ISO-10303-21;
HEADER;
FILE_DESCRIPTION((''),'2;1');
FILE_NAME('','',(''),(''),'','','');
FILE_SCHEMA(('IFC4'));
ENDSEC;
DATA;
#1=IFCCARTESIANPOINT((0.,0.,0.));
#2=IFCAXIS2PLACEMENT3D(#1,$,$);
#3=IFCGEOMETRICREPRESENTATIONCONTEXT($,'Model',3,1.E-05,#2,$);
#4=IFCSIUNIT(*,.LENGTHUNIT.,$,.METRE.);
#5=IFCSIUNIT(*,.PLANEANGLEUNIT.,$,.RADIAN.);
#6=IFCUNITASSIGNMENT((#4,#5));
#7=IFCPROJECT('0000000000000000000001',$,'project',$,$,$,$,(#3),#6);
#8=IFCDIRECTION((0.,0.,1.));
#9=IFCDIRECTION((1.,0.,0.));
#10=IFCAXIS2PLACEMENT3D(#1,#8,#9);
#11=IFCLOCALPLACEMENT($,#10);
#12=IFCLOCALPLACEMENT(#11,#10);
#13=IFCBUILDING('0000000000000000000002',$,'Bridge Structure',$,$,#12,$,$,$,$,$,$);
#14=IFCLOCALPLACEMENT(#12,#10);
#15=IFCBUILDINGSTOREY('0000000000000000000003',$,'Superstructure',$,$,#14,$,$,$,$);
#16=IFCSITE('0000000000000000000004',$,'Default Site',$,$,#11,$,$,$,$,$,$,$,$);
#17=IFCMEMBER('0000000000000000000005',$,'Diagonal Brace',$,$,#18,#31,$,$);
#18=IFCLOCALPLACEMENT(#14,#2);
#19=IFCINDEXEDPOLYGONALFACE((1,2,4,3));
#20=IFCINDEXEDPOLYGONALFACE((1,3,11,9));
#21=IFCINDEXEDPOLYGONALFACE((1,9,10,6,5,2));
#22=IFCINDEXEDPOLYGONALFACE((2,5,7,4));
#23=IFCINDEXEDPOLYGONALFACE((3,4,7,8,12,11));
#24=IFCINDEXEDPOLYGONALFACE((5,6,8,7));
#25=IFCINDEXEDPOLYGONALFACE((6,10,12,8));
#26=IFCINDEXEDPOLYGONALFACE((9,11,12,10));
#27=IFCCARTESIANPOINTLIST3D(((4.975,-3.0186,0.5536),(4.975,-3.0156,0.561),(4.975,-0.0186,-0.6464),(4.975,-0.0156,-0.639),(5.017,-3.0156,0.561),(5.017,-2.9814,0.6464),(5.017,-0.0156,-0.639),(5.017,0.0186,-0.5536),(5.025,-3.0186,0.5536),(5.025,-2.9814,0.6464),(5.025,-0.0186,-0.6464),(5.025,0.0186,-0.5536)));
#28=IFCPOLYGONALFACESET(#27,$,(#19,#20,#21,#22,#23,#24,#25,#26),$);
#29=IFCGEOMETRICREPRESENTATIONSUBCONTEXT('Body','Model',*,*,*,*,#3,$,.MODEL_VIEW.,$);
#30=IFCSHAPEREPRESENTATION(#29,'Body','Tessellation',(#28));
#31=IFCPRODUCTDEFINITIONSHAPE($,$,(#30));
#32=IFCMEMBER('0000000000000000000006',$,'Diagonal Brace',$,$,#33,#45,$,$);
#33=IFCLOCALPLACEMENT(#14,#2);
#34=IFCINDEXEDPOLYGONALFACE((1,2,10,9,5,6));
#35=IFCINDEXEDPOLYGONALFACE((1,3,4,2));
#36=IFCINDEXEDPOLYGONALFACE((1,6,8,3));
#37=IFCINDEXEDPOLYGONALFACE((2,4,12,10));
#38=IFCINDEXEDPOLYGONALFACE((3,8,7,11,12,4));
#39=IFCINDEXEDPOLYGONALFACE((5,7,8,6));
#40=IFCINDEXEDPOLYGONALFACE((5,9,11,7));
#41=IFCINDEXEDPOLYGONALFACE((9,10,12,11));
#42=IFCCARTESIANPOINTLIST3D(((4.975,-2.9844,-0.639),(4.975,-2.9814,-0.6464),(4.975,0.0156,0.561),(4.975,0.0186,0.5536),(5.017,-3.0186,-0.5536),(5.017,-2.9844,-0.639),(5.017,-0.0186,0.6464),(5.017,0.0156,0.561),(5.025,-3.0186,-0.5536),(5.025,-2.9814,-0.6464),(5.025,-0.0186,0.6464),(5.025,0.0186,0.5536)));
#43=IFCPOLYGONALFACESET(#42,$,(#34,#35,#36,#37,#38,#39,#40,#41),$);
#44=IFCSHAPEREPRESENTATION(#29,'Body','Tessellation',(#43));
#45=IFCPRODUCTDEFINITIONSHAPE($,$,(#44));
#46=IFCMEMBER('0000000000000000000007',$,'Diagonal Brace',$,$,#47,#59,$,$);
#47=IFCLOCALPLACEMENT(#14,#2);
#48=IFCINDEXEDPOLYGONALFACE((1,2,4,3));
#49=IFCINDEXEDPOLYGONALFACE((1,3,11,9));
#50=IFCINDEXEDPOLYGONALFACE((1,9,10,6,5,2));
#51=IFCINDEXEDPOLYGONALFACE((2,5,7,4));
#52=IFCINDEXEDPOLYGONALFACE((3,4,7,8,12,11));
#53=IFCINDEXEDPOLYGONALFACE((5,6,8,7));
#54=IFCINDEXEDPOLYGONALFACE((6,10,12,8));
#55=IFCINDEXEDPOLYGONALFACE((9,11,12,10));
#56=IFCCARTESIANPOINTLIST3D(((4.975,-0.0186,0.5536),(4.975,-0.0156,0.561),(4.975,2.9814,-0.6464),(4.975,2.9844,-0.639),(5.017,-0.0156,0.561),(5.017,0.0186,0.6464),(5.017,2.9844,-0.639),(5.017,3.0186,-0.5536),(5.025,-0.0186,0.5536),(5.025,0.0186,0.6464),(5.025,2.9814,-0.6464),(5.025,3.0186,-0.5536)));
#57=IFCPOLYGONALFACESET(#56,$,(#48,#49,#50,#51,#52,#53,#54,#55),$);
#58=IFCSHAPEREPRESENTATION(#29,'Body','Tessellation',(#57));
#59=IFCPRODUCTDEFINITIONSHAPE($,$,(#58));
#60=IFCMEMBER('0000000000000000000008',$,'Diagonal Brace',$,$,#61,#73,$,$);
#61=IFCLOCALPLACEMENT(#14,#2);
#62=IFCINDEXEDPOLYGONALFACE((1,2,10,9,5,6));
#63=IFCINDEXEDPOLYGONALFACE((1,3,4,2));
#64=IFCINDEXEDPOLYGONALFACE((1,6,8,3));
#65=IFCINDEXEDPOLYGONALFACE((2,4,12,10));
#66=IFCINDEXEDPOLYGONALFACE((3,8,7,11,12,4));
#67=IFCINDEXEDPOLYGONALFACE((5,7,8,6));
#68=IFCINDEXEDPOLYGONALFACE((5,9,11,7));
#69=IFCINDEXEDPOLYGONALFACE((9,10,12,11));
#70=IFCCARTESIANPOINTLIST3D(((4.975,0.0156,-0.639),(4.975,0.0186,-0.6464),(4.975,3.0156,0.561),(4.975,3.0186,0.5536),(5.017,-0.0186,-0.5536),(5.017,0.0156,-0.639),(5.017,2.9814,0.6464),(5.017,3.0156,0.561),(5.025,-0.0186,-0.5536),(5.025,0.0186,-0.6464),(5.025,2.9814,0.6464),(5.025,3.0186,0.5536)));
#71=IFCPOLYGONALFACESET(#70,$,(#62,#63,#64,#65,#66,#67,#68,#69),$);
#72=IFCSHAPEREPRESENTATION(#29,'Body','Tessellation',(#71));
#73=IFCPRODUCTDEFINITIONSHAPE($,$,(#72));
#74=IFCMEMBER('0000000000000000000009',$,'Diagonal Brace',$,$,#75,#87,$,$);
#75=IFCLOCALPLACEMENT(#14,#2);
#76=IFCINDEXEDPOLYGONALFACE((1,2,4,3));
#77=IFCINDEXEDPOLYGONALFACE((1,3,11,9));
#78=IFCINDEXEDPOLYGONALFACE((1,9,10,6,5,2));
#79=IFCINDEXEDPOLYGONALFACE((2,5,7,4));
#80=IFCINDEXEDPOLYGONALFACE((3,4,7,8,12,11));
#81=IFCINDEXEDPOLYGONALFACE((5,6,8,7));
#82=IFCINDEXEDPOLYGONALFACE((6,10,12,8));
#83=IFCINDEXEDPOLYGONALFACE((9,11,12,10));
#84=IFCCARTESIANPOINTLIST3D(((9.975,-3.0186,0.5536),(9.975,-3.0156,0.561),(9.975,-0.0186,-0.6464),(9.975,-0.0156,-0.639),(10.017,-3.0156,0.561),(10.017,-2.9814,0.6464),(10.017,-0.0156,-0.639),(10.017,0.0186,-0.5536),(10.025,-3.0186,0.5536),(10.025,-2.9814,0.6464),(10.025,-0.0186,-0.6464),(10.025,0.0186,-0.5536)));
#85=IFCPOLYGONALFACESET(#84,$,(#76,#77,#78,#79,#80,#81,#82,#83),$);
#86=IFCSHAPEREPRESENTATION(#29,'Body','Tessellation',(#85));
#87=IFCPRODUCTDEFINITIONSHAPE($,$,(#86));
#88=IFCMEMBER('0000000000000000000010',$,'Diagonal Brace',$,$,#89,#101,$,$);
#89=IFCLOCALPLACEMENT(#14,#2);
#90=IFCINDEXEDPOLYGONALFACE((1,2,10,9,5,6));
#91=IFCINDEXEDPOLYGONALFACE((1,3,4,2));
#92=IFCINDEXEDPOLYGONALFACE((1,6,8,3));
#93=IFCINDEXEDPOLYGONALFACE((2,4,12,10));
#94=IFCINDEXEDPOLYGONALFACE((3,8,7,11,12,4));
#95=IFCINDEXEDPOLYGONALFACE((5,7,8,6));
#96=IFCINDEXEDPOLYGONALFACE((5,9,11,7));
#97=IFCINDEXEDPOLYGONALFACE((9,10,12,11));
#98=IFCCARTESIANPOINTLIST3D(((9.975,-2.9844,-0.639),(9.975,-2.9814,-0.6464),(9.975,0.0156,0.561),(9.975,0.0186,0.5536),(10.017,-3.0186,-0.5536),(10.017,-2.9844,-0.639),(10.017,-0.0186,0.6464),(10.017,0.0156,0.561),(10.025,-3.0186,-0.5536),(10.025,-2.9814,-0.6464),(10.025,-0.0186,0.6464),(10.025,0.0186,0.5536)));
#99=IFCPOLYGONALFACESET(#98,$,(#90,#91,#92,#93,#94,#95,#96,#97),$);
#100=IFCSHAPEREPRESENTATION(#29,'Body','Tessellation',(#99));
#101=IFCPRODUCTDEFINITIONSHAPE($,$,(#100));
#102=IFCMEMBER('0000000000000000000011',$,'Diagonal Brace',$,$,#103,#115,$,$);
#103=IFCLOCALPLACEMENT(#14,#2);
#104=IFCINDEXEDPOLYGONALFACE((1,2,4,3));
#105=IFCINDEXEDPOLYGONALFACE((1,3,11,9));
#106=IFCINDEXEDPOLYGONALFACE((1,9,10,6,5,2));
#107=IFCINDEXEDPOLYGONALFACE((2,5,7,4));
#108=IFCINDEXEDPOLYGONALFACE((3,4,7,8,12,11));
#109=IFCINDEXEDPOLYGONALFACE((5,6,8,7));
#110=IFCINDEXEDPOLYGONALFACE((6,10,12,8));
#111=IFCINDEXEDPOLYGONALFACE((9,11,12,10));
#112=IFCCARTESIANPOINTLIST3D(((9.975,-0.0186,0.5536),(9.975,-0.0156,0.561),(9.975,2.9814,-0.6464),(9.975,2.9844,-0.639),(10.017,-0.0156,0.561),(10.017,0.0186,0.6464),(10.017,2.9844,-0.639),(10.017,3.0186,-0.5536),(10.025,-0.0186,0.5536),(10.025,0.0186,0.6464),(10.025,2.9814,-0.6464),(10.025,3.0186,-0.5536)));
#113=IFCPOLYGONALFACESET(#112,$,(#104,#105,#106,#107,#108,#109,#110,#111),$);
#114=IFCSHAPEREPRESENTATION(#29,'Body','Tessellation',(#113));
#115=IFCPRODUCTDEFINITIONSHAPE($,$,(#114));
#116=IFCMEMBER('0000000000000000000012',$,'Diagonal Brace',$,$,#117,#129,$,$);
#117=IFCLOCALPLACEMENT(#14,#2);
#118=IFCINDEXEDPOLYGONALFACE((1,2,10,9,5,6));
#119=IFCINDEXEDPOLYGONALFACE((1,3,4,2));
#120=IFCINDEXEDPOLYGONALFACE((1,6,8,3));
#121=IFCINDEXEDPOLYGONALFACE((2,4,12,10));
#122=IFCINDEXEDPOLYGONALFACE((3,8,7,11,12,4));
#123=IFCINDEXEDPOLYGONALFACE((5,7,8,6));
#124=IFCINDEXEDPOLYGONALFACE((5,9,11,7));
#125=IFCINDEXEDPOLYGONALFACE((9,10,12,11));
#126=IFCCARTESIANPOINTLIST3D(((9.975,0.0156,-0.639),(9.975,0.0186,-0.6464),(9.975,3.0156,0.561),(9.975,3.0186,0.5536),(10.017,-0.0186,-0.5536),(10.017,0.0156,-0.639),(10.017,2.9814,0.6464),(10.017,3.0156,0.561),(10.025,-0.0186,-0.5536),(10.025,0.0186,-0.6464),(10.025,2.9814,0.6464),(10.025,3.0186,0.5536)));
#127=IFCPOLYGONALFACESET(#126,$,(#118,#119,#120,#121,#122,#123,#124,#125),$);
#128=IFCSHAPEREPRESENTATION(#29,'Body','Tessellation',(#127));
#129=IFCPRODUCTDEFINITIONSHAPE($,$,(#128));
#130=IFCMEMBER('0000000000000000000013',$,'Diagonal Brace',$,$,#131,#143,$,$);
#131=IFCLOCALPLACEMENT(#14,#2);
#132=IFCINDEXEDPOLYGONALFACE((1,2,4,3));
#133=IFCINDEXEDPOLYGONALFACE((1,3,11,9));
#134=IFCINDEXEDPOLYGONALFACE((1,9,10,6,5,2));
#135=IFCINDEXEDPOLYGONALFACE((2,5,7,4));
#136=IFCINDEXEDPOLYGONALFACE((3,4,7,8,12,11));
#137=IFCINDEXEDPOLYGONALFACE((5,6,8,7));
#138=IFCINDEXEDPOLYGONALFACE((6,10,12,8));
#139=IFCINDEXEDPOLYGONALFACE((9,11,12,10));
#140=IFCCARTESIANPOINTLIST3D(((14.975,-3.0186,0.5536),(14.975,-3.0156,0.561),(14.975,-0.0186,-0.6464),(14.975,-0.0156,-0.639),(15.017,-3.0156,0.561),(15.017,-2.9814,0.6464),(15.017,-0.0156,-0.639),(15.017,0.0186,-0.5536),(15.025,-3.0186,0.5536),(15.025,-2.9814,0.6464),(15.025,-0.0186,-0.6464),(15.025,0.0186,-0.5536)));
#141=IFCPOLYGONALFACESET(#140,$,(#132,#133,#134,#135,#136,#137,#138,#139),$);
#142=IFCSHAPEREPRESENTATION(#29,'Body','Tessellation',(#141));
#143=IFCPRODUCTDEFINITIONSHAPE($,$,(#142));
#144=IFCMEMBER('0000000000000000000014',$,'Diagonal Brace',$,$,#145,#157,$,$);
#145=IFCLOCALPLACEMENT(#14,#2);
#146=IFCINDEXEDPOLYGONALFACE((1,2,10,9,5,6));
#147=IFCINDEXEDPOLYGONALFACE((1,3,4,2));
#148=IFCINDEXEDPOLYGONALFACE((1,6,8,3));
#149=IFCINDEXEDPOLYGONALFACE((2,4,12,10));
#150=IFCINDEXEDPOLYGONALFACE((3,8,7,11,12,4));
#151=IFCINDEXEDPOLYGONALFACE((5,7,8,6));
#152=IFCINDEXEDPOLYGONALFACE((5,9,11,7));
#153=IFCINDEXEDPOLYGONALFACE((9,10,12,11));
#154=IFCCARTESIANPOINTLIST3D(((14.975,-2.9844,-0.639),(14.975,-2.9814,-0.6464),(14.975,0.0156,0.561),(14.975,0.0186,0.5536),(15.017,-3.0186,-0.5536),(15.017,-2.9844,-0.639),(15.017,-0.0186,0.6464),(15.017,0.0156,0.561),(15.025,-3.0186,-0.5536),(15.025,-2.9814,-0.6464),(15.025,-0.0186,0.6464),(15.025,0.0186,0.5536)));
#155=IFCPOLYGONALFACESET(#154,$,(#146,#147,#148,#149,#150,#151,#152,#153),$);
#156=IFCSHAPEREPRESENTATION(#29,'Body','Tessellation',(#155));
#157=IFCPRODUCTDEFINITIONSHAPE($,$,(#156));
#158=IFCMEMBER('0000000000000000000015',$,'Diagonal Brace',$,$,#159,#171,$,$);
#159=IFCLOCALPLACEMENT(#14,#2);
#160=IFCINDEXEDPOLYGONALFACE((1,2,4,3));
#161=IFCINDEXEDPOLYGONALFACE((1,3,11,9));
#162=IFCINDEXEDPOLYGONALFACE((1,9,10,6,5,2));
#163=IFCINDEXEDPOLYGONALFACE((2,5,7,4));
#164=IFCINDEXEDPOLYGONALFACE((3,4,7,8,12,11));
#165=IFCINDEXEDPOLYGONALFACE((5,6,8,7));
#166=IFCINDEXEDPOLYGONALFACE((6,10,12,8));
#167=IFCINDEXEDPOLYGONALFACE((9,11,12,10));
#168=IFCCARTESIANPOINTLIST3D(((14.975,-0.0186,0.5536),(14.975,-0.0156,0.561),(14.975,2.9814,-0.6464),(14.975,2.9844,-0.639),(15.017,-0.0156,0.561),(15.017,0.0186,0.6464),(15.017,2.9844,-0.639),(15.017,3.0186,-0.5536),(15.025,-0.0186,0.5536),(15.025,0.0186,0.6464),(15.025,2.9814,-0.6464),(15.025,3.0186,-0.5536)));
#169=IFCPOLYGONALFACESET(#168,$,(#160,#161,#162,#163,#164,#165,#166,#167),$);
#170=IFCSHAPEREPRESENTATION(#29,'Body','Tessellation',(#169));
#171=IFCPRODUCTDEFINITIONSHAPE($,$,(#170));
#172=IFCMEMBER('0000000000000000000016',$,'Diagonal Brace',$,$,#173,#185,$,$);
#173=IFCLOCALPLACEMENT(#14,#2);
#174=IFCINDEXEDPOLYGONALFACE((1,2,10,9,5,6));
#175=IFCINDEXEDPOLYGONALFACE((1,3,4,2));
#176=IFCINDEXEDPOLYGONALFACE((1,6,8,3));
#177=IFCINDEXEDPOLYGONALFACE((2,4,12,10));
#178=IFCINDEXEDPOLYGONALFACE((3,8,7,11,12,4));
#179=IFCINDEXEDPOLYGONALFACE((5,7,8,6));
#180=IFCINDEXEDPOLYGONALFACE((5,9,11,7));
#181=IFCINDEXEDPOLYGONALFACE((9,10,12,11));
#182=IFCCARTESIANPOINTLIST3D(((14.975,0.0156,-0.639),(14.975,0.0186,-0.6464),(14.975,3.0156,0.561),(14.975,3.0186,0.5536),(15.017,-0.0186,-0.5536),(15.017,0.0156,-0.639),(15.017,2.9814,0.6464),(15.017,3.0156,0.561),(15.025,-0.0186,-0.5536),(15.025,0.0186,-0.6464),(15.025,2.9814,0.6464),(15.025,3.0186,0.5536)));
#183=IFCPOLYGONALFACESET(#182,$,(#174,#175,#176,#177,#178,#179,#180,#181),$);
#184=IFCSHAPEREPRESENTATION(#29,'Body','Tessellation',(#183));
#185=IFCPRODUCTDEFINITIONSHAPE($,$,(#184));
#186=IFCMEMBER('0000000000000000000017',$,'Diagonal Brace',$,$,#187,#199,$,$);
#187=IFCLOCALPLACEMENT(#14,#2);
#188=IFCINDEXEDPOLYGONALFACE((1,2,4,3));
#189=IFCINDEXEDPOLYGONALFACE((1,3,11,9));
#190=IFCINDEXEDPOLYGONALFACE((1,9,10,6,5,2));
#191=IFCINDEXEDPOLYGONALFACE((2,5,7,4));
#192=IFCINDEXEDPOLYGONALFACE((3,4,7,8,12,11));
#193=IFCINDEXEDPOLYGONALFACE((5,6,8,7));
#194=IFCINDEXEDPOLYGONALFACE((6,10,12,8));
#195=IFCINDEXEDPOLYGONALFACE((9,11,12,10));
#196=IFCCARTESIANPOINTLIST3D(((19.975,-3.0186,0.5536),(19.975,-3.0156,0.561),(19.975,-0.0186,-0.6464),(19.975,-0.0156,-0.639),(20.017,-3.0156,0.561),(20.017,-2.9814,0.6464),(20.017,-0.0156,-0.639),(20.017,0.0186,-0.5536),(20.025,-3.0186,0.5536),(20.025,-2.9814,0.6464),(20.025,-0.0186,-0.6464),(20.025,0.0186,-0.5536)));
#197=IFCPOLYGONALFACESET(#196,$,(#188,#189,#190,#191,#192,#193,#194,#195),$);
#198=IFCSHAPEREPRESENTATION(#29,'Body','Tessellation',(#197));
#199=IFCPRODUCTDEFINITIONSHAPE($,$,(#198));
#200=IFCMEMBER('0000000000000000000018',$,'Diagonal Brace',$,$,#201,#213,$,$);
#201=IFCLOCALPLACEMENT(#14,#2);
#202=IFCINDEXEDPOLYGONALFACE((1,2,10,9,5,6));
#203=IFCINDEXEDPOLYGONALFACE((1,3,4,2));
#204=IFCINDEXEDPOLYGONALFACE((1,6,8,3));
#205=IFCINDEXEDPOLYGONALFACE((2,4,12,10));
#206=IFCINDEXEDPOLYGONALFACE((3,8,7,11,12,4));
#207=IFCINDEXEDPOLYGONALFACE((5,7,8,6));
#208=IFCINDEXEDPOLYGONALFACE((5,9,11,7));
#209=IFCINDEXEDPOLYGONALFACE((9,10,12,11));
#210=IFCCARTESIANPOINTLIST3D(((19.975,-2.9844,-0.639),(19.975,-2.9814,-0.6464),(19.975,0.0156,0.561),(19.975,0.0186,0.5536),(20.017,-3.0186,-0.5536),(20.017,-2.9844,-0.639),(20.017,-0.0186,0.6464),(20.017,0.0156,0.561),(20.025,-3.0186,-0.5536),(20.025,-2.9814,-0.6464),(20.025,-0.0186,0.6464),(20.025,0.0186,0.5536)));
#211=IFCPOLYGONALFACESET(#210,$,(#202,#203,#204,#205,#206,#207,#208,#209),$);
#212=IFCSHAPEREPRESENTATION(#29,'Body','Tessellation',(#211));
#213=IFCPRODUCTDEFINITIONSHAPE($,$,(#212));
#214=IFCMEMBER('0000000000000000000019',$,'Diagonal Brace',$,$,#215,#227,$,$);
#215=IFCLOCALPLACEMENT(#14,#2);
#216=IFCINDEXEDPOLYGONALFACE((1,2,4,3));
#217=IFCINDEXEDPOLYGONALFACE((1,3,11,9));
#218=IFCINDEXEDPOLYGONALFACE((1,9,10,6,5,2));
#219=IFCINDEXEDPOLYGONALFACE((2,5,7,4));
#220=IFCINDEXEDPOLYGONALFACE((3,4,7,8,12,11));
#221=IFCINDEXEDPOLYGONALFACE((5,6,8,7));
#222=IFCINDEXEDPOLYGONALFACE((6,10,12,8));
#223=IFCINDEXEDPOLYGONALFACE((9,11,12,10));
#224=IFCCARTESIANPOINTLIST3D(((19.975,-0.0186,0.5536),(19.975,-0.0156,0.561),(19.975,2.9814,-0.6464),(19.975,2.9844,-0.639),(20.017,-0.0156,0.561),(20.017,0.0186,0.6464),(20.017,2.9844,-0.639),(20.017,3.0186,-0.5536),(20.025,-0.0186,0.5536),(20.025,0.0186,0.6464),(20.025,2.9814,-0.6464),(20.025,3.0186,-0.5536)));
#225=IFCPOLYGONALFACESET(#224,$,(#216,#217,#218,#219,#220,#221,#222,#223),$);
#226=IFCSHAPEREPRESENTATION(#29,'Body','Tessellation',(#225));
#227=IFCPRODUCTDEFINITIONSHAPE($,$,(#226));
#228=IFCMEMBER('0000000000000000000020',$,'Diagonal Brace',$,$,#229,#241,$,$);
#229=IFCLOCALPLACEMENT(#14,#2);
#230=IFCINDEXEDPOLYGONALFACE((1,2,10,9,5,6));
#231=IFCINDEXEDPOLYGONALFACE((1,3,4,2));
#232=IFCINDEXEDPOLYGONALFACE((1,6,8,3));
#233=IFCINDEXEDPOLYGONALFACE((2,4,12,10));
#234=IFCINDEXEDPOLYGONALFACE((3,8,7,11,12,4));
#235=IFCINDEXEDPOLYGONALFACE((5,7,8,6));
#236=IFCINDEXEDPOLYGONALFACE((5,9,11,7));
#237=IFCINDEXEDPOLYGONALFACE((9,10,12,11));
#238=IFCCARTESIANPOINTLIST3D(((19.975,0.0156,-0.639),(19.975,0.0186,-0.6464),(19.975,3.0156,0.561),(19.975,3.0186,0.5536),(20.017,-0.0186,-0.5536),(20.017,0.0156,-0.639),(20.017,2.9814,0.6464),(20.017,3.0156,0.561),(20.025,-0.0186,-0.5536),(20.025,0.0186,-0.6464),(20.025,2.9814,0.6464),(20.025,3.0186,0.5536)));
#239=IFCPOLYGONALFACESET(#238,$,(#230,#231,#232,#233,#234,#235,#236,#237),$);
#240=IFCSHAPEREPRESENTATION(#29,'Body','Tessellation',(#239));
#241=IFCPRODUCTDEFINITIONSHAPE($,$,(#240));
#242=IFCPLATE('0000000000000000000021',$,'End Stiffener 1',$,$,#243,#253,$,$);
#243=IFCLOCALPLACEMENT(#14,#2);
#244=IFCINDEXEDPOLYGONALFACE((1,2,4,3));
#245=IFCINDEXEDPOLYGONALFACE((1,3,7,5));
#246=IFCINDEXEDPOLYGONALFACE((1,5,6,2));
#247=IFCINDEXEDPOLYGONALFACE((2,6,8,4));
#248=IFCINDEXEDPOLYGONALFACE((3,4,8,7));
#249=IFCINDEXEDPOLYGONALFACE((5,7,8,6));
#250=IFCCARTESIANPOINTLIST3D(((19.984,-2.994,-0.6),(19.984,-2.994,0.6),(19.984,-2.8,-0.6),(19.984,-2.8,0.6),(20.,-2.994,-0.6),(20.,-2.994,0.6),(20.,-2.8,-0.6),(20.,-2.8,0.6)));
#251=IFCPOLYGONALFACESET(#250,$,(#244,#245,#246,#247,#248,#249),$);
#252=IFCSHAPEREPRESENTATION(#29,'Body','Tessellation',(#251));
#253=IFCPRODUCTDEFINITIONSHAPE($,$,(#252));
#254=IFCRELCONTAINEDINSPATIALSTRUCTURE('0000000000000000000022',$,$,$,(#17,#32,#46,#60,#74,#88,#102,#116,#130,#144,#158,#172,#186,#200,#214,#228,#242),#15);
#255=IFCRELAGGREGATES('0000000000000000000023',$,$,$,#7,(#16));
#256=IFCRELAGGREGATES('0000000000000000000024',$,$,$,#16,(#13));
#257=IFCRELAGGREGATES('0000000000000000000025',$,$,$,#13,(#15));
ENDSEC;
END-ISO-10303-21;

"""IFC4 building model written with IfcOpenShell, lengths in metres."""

from ifc_helpers import new_model, si_unit, frame, origin, origin_with_axes, origin_2d_with_axis, place, context, subcontext, project, spatial, rectangle, l_section, extrude, element, save


model = new_model("IFC4")

# Units and contexts
model_context = context("Model", 3, precision=1e-05, world=origin())
body_context = subcontext(model_context, "Body", "Model", "MODEL_VIEW")
ifc_project = project(units=[si_unit("LENGTHUNIT", "METRE"), si_unit("PLANEANGLEUNIT", "RADIAN")], contexts=[model_context])

# Site, building, storey
site_placement = place(None, origin_with_axes())
site = spatial("IfcSite", under=ifc_project, at=site_placement, Name="Default Site")
building_placement = place(site_placement, origin_with_axes())
building = spatial("IfcBuilding", under=site, at=building_placement, Name="Bridge Structure")
storey_placement = place(building_placement, origin_with_axes())
storey = spatial("IfcBuildingStorey", under=building, at=storey_placement, Name="Superstructure")

# Members
for number, where, z_axis, x_axis, name in (
    (1, (5.0, -3.0, 0.6), (0.0, 0.928477, -0.371391), (-1.0, 0.0, 0.0), "Diagonal Brace"),
    (2, (5.0, -3.0, -0.6), (0.0, 0.928477, 0.371391), (-1.0, 0.0, 0.0), "Diagonal Brace"),
    (3, (5.0, 0.0, 0.6), (0.0, 0.928477, -0.371391), (-1.0, 0.0, 0.0), "Diagonal Brace"),
    (4, (5.0, 0.0, -0.6), (0.0, 0.928477, 0.371391), (-1.0, 0.0, 0.0), "Diagonal Brace"),
    (5, (10.0, -3.0, 0.6), (0.0, 0.928477, -0.371391), (-1.0, 0.0, 0.0), "Diagonal Brace"),
    (6, (10.0, -3.0, -0.6), (0.0, 0.928477, 0.371391), (-1.0, 0.0, 0.0), "Diagonal Brace"),
    (7, (10.0, 0.0, 0.6), (0.0, 0.928477, -0.371391), (-1.0, 0.0, 0.0), "Diagonal Brace"),
    (8, (10.0, 0.0, -0.6), (0.0, 0.928477, 0.371391), (-1.0, 0.0, 0.0), "Diagonal Brace"),
    (9, (15.0, -3.0, 0.6), (0.0, 0.928477, -0.371391), (-1.0, 0.0, 0.0), "Diagonal Brace"),
    (10, (15.0, -3.0, -0.6), (0.0, 0.928477, 0.371391), (-1.0, 0.0, 0.0), "Diagonal Brace"),
    (11, (15.0, 0.0, 0.6), (0.0, 0.928477, -0.371391), (-1.0, 0.0, 0.0), "Diagonal Brace"),
    (12, (15.0, 0.0, -0.6), (0.0, 0.928477, 0.371391), (-1.0, 0.0, 0.0), "Diagonal Brace"),
    (13, (20.0, -3.0, 0.6), (0.0, 0.928477, -0.371391), (-1.0, 0.0, 0.0), "Diagonal Brace"),
    (14, (20.0, -3.0, -0.6), (0.0, 0.928477, 0.371391), (-1.0, 0.0, 0.0), "Diagonal Brace"),
    (15, (20.0, 0.0, 0.6), (0.0, 0.928477, -0.371391), (-1.0, 0.0, 0.0), "Diagonal Brace"),
    (16, (20.0, 0.0, -0.6), (0.0, 0.928477, 0.371391), (-1.0, 0.0, 0.0), "Diagonal Brace"),
):
    element("IfcMember", number, at=place(storey_placement, frame(where, z_axis=z_axis, x_axis=x_axis)), inside=storey, Name=name, context=body_context, shape_type="SweptSolid", body=[
        extrude(l_section(Depth=0.1, Width=0.05, Thickness=0.008, at=origin_2d_with_axis()), origin_with_axes(), (0.0, 0.0, 1.0), 3.2311),
    ])

# Plate
for number, where, z_axis, x_axis, name in (
    (17, (19.992, -2.897, -0.6), (0.0, 0.0, 1.0), (1.0, 0.0, 0.0), "End Stiffener 1"),
):
    element("IfcPlate", number, at=place(storey_placement, frame(where, z_axis=z_axis, x_axis=x_axis)), inside=storey, Name=name, context=body_context, shape_type="SweptSolid", body=[
        extrude(rectangle(XDim=0.016, YDim=0.194, at=origin_2d_with_axis()), origin_with_axes(), (0.0, 0.0, 1.0), 1.2),
    ])

save(model, "model.ifc")
